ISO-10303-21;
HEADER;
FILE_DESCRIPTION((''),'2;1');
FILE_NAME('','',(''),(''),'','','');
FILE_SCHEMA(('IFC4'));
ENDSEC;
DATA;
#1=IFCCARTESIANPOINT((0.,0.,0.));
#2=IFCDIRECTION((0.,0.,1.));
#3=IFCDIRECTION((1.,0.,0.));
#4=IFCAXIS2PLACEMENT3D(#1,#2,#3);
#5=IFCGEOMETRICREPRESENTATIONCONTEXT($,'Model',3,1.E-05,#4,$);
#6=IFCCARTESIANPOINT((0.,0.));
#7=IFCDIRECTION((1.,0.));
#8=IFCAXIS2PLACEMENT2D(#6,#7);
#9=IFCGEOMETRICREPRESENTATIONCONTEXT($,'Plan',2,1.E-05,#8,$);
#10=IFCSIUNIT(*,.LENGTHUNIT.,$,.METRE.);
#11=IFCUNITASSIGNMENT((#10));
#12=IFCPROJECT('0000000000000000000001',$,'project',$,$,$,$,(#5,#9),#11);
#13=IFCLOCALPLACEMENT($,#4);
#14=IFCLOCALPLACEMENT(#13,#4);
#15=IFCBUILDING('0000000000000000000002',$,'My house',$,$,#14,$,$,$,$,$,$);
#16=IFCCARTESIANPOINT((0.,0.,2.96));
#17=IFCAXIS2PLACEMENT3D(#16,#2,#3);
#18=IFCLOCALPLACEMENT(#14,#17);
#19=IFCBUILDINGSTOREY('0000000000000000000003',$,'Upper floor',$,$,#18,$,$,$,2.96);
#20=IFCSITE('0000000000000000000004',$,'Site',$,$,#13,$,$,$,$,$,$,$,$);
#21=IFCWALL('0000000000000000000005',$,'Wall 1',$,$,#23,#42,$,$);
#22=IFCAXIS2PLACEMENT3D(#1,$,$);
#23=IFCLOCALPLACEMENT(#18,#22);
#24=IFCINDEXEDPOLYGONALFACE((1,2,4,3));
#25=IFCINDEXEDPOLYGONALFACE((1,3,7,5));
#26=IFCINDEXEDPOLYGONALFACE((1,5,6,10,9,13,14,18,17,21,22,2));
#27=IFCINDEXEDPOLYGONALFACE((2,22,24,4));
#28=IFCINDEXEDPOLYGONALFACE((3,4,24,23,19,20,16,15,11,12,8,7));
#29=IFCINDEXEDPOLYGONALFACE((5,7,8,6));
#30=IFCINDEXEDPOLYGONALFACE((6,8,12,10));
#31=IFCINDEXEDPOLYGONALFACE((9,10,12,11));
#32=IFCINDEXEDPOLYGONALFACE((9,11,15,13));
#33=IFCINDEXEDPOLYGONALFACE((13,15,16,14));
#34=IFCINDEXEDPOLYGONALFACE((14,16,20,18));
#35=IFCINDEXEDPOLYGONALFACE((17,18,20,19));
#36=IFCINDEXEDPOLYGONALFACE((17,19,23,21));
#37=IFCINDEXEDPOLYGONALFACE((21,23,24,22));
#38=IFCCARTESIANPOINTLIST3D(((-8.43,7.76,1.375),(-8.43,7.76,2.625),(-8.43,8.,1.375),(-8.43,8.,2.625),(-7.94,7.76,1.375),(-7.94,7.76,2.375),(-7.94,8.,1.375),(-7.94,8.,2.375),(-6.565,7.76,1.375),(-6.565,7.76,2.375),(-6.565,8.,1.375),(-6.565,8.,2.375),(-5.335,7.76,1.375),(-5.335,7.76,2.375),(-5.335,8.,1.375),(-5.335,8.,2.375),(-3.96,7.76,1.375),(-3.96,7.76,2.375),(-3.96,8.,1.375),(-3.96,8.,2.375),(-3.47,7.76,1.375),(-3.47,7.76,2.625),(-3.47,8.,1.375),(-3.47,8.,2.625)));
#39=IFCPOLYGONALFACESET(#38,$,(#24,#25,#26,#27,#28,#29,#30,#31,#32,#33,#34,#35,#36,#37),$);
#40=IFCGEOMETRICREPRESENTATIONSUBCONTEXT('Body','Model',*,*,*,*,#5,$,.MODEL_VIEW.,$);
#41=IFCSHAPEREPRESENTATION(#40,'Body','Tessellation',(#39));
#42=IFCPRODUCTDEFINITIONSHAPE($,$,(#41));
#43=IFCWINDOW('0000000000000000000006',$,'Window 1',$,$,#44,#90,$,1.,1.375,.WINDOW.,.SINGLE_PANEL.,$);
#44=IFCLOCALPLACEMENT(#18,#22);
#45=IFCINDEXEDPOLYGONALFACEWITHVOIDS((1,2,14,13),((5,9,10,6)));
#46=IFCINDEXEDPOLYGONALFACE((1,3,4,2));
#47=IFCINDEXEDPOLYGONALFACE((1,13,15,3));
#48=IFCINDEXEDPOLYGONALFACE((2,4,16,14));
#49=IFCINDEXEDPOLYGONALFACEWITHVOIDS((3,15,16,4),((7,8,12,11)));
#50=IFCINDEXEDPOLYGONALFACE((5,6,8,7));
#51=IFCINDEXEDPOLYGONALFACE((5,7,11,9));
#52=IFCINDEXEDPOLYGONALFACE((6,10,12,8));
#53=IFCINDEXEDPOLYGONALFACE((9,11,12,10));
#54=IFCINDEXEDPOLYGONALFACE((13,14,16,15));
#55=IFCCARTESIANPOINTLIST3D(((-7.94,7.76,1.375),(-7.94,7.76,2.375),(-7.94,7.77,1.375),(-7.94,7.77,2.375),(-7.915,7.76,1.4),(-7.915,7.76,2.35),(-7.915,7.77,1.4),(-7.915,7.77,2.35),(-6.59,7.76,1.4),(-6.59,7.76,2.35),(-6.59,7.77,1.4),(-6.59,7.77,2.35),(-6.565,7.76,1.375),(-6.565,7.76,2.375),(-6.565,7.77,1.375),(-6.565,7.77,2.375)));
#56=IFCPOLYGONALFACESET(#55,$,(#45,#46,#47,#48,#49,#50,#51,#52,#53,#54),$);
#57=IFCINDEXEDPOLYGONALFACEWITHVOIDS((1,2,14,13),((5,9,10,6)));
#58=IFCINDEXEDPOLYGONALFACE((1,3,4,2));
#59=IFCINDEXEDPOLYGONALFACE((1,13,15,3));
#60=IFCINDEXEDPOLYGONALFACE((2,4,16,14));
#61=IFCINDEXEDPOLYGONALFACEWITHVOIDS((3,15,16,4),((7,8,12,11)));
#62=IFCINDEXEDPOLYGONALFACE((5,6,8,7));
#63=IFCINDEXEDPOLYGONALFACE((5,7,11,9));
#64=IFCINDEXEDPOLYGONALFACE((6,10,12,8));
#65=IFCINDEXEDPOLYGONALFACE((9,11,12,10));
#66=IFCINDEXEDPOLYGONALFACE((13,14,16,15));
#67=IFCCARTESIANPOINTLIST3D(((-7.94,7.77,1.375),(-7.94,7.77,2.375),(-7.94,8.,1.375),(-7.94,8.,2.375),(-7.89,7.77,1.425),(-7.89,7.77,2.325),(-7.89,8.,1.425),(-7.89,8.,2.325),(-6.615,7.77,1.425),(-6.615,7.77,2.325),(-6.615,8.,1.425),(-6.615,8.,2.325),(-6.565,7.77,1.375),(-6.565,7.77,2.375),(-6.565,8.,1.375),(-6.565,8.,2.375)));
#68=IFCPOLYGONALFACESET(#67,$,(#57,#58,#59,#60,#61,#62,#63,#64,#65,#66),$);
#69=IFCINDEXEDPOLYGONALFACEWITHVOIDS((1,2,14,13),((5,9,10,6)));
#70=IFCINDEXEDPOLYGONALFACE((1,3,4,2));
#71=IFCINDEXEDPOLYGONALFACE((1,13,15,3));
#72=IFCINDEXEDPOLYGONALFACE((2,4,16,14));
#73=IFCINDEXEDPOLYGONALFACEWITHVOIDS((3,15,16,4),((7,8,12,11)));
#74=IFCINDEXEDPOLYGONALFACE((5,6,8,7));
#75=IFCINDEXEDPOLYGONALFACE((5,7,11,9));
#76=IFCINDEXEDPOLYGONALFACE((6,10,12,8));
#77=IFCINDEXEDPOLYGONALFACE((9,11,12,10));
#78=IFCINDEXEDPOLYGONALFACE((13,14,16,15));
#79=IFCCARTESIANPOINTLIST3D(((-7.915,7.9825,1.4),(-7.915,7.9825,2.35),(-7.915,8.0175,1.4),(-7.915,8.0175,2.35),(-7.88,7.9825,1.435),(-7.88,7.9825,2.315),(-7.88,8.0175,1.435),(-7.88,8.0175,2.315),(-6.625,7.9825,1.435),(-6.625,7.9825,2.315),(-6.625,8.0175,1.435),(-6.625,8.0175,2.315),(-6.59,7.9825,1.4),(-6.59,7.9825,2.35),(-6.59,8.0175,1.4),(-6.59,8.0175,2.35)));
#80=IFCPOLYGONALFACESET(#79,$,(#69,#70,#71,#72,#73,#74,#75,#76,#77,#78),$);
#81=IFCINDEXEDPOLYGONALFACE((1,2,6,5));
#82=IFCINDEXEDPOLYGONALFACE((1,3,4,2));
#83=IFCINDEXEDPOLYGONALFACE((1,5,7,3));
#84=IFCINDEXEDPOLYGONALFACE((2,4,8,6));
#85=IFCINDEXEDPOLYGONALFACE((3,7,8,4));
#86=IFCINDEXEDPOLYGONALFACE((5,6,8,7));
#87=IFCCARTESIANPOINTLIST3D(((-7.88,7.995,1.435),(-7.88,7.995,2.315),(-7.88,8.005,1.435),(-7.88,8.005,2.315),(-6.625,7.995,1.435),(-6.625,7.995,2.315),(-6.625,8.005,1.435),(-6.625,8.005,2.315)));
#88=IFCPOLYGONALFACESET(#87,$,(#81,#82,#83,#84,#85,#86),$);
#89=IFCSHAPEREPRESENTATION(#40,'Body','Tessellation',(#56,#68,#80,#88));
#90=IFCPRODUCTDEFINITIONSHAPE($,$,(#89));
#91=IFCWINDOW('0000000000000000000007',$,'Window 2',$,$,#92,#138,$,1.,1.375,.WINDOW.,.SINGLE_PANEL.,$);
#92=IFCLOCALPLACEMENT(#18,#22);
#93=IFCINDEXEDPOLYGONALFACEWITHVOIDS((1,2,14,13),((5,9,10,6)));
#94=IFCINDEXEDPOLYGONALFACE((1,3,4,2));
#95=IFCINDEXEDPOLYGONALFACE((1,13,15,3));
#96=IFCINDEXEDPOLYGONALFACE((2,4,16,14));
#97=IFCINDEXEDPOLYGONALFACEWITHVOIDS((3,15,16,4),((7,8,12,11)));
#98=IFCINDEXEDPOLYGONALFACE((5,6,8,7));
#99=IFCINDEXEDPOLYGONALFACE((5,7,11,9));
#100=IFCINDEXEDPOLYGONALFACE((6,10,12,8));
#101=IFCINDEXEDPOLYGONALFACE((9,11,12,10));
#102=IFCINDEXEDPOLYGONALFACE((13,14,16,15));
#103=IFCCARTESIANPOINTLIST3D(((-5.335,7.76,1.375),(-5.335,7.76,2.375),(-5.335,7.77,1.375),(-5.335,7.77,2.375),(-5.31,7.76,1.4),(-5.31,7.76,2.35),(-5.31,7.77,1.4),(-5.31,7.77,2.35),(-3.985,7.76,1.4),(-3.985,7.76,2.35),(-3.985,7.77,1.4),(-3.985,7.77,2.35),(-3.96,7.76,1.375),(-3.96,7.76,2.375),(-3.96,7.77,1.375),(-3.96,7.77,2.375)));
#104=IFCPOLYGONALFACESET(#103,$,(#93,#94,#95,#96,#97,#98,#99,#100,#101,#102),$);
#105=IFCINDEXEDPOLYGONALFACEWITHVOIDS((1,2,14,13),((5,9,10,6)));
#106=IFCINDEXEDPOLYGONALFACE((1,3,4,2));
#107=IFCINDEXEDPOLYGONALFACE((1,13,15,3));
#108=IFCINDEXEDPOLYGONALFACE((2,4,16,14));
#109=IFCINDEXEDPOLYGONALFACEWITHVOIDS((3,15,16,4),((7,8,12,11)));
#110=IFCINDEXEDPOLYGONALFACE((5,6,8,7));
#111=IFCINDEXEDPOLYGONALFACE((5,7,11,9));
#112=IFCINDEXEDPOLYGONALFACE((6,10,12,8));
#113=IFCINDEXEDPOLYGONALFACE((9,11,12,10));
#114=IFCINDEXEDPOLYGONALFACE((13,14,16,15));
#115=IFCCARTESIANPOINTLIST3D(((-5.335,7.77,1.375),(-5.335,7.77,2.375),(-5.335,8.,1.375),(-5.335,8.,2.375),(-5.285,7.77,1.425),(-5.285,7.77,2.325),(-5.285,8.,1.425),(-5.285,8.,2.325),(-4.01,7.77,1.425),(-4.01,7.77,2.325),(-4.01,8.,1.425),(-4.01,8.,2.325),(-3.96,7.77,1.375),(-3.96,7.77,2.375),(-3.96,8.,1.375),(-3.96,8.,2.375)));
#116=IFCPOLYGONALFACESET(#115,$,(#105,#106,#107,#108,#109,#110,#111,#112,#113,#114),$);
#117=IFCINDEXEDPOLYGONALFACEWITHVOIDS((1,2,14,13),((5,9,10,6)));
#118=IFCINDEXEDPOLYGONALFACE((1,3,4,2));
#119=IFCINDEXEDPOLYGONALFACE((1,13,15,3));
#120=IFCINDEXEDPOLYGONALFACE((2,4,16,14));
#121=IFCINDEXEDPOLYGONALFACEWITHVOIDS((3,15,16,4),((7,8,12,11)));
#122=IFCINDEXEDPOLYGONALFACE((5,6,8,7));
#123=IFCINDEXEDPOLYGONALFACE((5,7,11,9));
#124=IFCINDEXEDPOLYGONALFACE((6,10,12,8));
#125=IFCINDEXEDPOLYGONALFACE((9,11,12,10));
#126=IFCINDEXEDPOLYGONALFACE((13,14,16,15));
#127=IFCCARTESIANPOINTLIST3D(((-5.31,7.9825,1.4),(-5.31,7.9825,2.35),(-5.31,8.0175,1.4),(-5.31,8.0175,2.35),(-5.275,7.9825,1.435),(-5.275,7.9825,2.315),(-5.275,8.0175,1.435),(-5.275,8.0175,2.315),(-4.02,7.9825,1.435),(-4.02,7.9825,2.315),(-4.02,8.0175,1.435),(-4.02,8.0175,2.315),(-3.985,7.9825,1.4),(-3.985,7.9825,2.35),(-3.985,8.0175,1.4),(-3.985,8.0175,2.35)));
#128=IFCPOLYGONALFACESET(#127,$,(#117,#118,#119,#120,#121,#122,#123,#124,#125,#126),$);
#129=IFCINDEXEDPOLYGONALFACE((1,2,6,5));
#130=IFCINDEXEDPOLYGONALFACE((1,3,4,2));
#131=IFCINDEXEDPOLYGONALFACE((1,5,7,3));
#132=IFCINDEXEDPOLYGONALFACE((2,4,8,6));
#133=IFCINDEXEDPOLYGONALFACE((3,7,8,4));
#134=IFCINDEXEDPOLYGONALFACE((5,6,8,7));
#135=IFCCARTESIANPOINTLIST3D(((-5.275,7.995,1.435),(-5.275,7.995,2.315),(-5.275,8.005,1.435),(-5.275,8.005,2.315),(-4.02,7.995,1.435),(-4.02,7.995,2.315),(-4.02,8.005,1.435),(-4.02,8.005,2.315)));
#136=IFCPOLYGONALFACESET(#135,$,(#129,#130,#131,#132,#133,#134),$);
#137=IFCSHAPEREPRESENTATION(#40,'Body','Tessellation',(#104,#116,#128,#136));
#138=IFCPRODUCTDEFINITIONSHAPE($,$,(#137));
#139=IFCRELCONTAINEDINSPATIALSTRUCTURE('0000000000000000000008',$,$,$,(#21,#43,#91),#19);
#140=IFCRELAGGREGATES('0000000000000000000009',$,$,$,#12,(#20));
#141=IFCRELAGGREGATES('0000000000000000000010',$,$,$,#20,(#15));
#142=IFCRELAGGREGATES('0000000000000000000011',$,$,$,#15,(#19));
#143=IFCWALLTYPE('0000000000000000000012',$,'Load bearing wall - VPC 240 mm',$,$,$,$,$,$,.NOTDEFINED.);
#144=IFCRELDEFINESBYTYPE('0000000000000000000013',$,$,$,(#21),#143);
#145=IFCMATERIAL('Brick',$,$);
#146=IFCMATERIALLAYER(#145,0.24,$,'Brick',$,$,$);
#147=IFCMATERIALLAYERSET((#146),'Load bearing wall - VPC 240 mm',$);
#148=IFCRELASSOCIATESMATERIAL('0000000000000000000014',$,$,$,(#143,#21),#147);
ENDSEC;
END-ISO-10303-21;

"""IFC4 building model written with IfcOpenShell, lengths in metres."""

from ifc_helpers import new_model, entity, si_unit, frame, origin_with_axes, origin_2d_with_axis, place, context, subcontext, project, spatial, line, indexed_curve, outline, extrude, shape, source, transform, mapped, material, layer, layer_set, layer_usage, type_object, element, fill, save


model = new_model("IFC4")

# Units and contexts
model_context = context("Model", 3, precision=1e-05, world=origin_with_axes())
plan_context = context("Plan", 2, precision=1e-05, world=origin_2d_with_axis())
body_context_1 = subcontext(model_context, "Body", "Model", "MODEL_VIEW")
body_context_2 = subcontext(plan_context, "Body", "Plan", "PLAN_VIEW")
ifc_project = project(units=[si_unit("LENGTHUNIT", "METRE")], contexts=[model_context, plan_context])

# Site, building, storey
site_placement = place(None, origin_with_axes())
site = spatial("IfcSite", under=ifc_project, at=site_placement, Name="Site")
building_placement = place(site_placement, origin_with_axes())
building = spatial("IfcBuilding", under=site, at=building_placement, Name="My house")
storey_placement = place(building_placement, frame((0.0, 0.0, 2.96), z_axis=(0.0, 0.0, 1.0), x_axis=(1.0, 0.0, 0.0)))
storey = spatial("IfcBuildingStorey", under=building, at=storey_placement, Name="Upper floor", Elevation=2.96)

# Wall, openings, windows
ifc_material_1 = material(Name="Brick")
ifc_layer = layer(ifc_material_1, 0.24, Name="Brick")
ifc_layer_set = layer_set([ifc_layer], Name="Load bearing wall - VPC 240 mm")
ifc_layer_usage_1 = layer_usage(ifc_layer_set, "AXIS2", "NEGATIVE", 0.24)
wall_type = type_object("IfcWallType", Name="Load bearing wall - VPC 240 mm", PredefinedType="NOTDEFINED", material=ifc_layer_set)
shared_shape_1 = source(origin_with_axes(), body_context_1, "Body", "SweptSolid", [
    extrude(outline(indexed_curve([(0.0, 0.0), (0.0, 0.24), (4.96, 0.24), (4.96, 0.0), (0.0, 0.0)], self_intersect=False)), origin_with_axes(), (0.0, 0.0, 1.0), 1.25),
])
wall_1_placement = place(storey_placement, frame((-8.43, 8.0, 1.375), z_axis=(0.0, 0.0, 1.0), x_axis=(-1.0, 0.0, 0.0)))
wall_1 = element("IfcWall", 1, at=wall_1_placement, inside=storey, type_object=wall_type, material=ifc_layer_usage_1, Name="Wall 1", context=body_context_1, shape_type="MappedRepresentation", body=[
    mapped(shared_shape_1, transform((0.0, 0.0, 0.0), x_axis=(-1.0, 0.0, 0.0), y_axis=(0.0, 1.0, 0.0), z_axis=(0.0, 0.0, 1.0), scale=1.0)),
])
shared_shape_2 = source(origin_with_axes(), body_context_1, "Body", "SweptSolid", [
    extrude(outline(indexed_curve([(0.0, 0.0), (0.0, 0.34), (1.375, 0.34), (1.375, 0.0), (0.0, 0.0)], self_intersect=False)), frame((0.0, -0.05, 0.0), z_axis=(0.0, 0.0, 1.0), x_axis=(1.0, 0.0, 0.0)), (0.0, 0.0, 1.0), 1.0),
])
opening_1_placement = place(wall_1_placement, frame((-0.49, 0.0, 0.0), z_axis=(0.0, 0.0, 1.0), x_axis=(1.0, 0.0, 0.0)))
opening_1 = element("IfcOpeningElement", 2, at=opening_1_placement, cuts=wall_1, PredefinedType="OPENING", context=body_context_1, shape_type="MappedRepresentation", body=[
    mapped(shared_shape_2, transform((0.0, 0.0, 0.0), x_axis=(-1.0, 0.0, 0.0), y_axis=(0.0, 1.0, 0.0), z_axis=(0.0, 0.0, 1.0), scale=1.0)),
])
shared_shape_3 = source(origin_with_axes(), body_context_1, "Body", "SweptSolid", [
    extrude(outline(indexed_curve([(0.0, 0.0), (0.0, 0.34), (1.375, 0.34), (1.375, 0.0), (0.0, 0.0)], self_intersect=False)), frame((0.0, -0.05, 0.0), z_axis=(0.0, 0.0, 1.0), x_axis=(1.0, 0.0, 0.0)), (0.0, 0.0, 1.0), 1.0),
])
opening_2_placement = place(wall_1_placement, frame((-3.095, 0.0, 0.0), z_axis=(0.0, 0.0, 1.0), x_axis=(1.0, 0.0, 0.0)))
opening_2 = element("IfcOpeningElement", 3, at=opening_2_placement, cuts=wall_1, PredefinedType="OPENING", context=body_context_1, shape_type="MappedRepresentation", body=[
    mapped(shared_shape_3, transform((0.0, 0.0, 0.0), x_axis=(-1.0, 0.0, 0.0), y_axis=(0.0, 1.0, 0.0), z_axis=(0.0, 0.0, 1.0), scale=1.0)),
])
shared_shape_4 = source(origin_with_axes(), body_context_1, "Body", "SweptSolid", [
    extrude(outline(indexed_curve([(0.0, 0.0), (1.375, 0.0), (1.375, 1.0), (0.0, 1.0)], segments=[line(1, 2, 3, 4, 1)]), holes=[indexed_curve([(0.025, 0.025), (1.35, 0.025), (1.35, 0.975), (0.025, 0.975)], segments=[line(1, 2, 3, 4, 1)])]), frame((0.0, 0.23, 0.0), z_axis=(0.0, -1.0, 0.0), x_axis=(1.0, 0.0, 0.0)), (0.0, 0.0, -1.0), 0.01),
    extrude(outline(indexed_curve([(0.0, 0.0), (1.375, 0.0), (1.375, 1.0), (0.0, 1.0)], segments=[line(1, 2, 3, 4, 1)]), holes=[indexed_curve([(0.05, 0.05), (1.325, 0.05), (1.325, 0.95), (0.05, 0.95)], segments=[line(1, 2, 3, 4, 1)])]), frame((0.0, 0.0, 0.0), z_axis=(0.0, -1.0, 0.0), x_axis=(1.0, 0.0, 0.0)), (0.0, 0.0, -1.0), 0.23),
    extrude(outline(indexed_curve([(0.0, 0.0), (1.325, 0.0), (1.325, 0.95), (0.0, 0.95)], segments=[line(1, 2, 3, 4, 1)]), holes=[indexed_curve([(0.035, 0.035), (1.29, 0.035), (1.29, 0.915), (0.035, 0.915)], segments=[line(1, 2, 3, 4, 1)])]), frame((0.025, -0.0175, 0.025), z_axis=(0.0, -1.0, 0.0), x_axis=(1.0, 0.0, 0.0)), (0.0, 0.0, -1.0), 0.035),
    extrude(outline(indexed_curve([(0.035, 0.035), (1.29, 0.035), (1.29, 0.915), (0.035, 0.915)], segments=[line(1, 2, 3, 4, 1)])), frame((0.025, -0.005, 0.025), z_axis=(0.0, -1.0, 0.0), x_axis=(1.0, 0.0, 0.0)), (0.0, 0.0, -1.0), 0.01),
])
shared_shape_5 = source(origin_with_axes(), body_context_2, "Body", "Curve2D", [
    entity("IfcIndexedPolyCurve", entity("IfcCartesianPointList2D", [[0.05, 0.0], [1.325, 0.0]])),
    entity("IfcIndexedPolyCurve", entity("IfcCartesianPointList2D", [[0.0, 0.24], [0.025, 0.24], [0.025, 0.23], [0.05, 0.23], [0.05, 0.0], [0.0, 0.0]]), [entity("IfcLineIndex", [1, 2, 3, 4, 5, 6, 1])]),
    entity("IfcIndexedPolyCurve", entity("IfcCartesianPointList2D", [[1.375, 0.24], [1.35, 0.24], [1.35, 0.23], [1.325, 0.23], [1.325, 0.0], [1.375, 0.0]]), [entity("IfcLineIndex", [1, 2, 3, 4, 5, 6, 1])]),
    entity("IfcIndexedPolyCurve", entity("IfcCartesianPointList2D", [[0.025, -0.0175], [0.06, -0.0175], [0.06, 0.0175], [0.025, 0.0175]]), [entity("IfcLineIndex", [1, 2, 3, 4, 1])]),
    entity("IfcIndexedPolyCurve", entity("IfcCartesianPointList2D", [[1.35, -0.0175], [1.315, -0.0175], [1.315, 0.0175], [1.35, 0.0175]]), [entity("IfcLineIndex", [1, 2, 3, 4, 1])]),
    entity("IfcIndexedPolyCurve", entity("IfcCartesianPointList2D", [[0.06, -0.0175], [1.315, -0.0175]])),
    entity("IfcIndexedPolyCurve", entity("IfcCartesianPointList2D", [[0.06, 0.0175], [1.315, 0.0175]])),
    entity("IfcIndexedPolyCurve", entity("IfcCartesianPointList2D", [[0.06, 0.0], [1.315, 0.0]])),
])
window_1_placement = place(opening_1_placement, frame((0.0, 0.0, 0.0), z_axis=(0.0, 0.0, 1.0), x_axis=(1.0, 0.0, 0.0)))
window_1 = element("IfcWindow", 4, at=window_1_placement, inside=storey, Name="Window 1", OverallHeight=1.0, OverallWidth=1.375, PartitioningType="SINGLE_PANEL", PredefinedType="WINDOW", shapes=[
    shape(body_context_1, "Body", "MappedRepresentation", [mapped(shared_shape_4, transform((0.0, 0.0, 0.0), x_axis=(-1.0, 0.0, 0.0), y_axis=(0.0, 1.0, 0.0), z_axis=(0.0, 0.0, 1.0), scale=1.0))]),
    shape(body_context_2, "Body", "MappedRepresentation", [mapped(shared_shape_5, transform((0.0, 0.0, 0.0), x_axis=(-1.0, 0.0, 0.0), y_axis=(0.0, 1.0, 0.0), z_axis=(0.0, 0.0, 1.0), scale=1.0))]),
])
fill(opening_1, window_1)
shared_shape_6 = source(origin_with_axes(), body_context_1, "Body", "SweptSolid", [
    extrude(outline(indexed_curve([(0.0, 0.0), (1.375, 0.0), (1.375, 1.0), (0.0, 1.0)], segments=[line(1, 2, 3, 4, 1)]), holes=[indexed_curve([(0.025, 0.025), (1.35, 0.025), (1.35, 0.975), (0.025, 0.975)], segments=[line(1, 2, 3, 4, 1)])]), frame((0.0, 0.23, 0.0), z_axis=(0.0, -1.0, 0.0), x_axis=(1.0, 0.0, 0.0)), (0.0, 0.0, -1.0), 0.01),
    extrude(outline(indexed_curve([(0.0, 0.0), (1.375, 0.0), (1.375, 1.0), (0.0, 1.0)], segments=[line(1, 2, 3, 4, 1)]), holes=[indexed_curve([(0.05, 0.05), (1.325, 0.05), (1.325, 0.95), (0.05, 0.95)], segments=[line(1, 2, 3, 4, 1)])]), frame((0.0, 0.0, 0.0), z_axis=(0.0, -1.0, 0.0), x_axis=(1.0, 0.0, 0.0)), (0.0, 0.0, -1.0), 0.23),
    extrude(outline(indexed_curve([(0.0, 0.0), (1.325, 0.0), (1.325, 0.95), (0.0, 0.95)], segments=[line(1, 2, 3, 4, 1)]), holes=[indexed_curve([(0.035, 0.035), (1.29, 0.035), (1.29, 0.915), (0.035, 0.915)], segments=[line(1, 2, 3, 4, 1)])]), frame((0.025, -0.0175, 0.025), z_axis=(0.0, -1.0, 0.0), x_axis=(1.0, 0.0, 0.0)), (0.0, 0.0, -1.0), 0.035),
    extrude(outline(indexed_curve([(0.035, 0.035), (1.29, 0.035), (1.29, 0.915), (0.035, 0.915)], segments=[line(1, 2, 3, 4, 1)])), frame((0.025, -0.005, 0.025), z_axis=(0.0, -1.0, 0.0), x_axis=(1.0, 0.0, 0.0)), (0.0, 0.0, -1.0), 0.01),
])
shared_shape_7 = source(origin_with_axes(), body_context_2, "Body", "Curve2D", [
    entity("IfcIndexedPolyCurve", entity("IfcCartesianPointList2D", [[0.05, 0.0], [1.325, 0.0]])),
    entity("IfcIndexedPolyCurve", entity("IfcCartesianPointList2D", [[0.0, 0.24], [0.025, 0.24], [0.025, 0.23], [0.05, 0.23], [0.05, 0.0], [0.0, 0.0]]), [entity("IfcLineIndex", [1, 2, 3, 4, 5, 6, 1])]),
    entity("IfcIndexedPolyCurve", entity("IfcCartesianPointList2D", [[1.375, 0.24], [1.35, 0.24], [1.35, 0.23], [1.325, 0.23], [1.325, 0.0], [1.375, 0.0]]), [entity("IfcLineIndex", [1, 2, 3, 4, 5, 6, 1])]),
    entity("IfcIndexedPolyCurve", entity("IfcCartesianPointList2D", [[0.025, -0.0175], [0.06, -0.0175], [0.06, 0.0175], [0.025, 0.0175]]), [entity("IfcLineIndex", [1, 2, 3, 4, 1])]),
    entity("IfcIndexedPolyCurve", entity("IfcCartesianPointList2D", [[1.35, -0.0175], [1.315, -0.0175], [1.315, 0.0175], [1.35, 0.0175]]), [entity("IfcLineIndex", [1, 2, 3, 4, 1])]),
    entity("IfcIndexedPolyCurve", entity("IfcCartesianPointList2D", [[0.06, -0.0175], [1.315, -0.0175]])),
    entity("IfcIndexedPolyCurve", entity("IfcCartesianPointList2D", [[0.06, 0.0175], [1.315, 0.0175]])),
    entity("IfcIndexedPolyCurve", entity("IfcCartesianPointList2D", [[0.06, 0.0], [1.315, 0.0]])),
])
window_2_placement = place(opening_2_placement, frame((0.0, 0.0, 0.0), z_axis=(0.0, 0.0, 1.0), x_axis=(1.0, 0.0, 0.0)))
window_2 = element("IfcWindow", 5, at=window_2_placement, inside=storey, Name="Window 2", OverallHeight=1.0, OverallWidth=1.375, PartitioningType="SINGLE_PANEL", PredefinedType="WINDOW", shapes=[
    shape(body_context_1, "Body", "MappedRepresentation", [mapped(shared_shape_6, transform((0.0, 0.0, 0.0), x_axis=(-1.0, 0.0, 0.0), y_axis=(0.0, 1.0, 0.0), z_axis=(0.0, 0.0, 1.0), scale=1.0))]),
    shape(body_context_2, "Body", "MappedRepresentation", [mapped(shared_shape_7, transform((0.0, 0.0, 0.0), x_axis=(-1.0, 0.0, 0.0), y_axis=(0.0, 1.0, 0.0), z_axis=(0.0, 0.0, 1.0), scale=1.0))]),
])
fill(opening_2, window_2)

save(model, "model.ifc")
